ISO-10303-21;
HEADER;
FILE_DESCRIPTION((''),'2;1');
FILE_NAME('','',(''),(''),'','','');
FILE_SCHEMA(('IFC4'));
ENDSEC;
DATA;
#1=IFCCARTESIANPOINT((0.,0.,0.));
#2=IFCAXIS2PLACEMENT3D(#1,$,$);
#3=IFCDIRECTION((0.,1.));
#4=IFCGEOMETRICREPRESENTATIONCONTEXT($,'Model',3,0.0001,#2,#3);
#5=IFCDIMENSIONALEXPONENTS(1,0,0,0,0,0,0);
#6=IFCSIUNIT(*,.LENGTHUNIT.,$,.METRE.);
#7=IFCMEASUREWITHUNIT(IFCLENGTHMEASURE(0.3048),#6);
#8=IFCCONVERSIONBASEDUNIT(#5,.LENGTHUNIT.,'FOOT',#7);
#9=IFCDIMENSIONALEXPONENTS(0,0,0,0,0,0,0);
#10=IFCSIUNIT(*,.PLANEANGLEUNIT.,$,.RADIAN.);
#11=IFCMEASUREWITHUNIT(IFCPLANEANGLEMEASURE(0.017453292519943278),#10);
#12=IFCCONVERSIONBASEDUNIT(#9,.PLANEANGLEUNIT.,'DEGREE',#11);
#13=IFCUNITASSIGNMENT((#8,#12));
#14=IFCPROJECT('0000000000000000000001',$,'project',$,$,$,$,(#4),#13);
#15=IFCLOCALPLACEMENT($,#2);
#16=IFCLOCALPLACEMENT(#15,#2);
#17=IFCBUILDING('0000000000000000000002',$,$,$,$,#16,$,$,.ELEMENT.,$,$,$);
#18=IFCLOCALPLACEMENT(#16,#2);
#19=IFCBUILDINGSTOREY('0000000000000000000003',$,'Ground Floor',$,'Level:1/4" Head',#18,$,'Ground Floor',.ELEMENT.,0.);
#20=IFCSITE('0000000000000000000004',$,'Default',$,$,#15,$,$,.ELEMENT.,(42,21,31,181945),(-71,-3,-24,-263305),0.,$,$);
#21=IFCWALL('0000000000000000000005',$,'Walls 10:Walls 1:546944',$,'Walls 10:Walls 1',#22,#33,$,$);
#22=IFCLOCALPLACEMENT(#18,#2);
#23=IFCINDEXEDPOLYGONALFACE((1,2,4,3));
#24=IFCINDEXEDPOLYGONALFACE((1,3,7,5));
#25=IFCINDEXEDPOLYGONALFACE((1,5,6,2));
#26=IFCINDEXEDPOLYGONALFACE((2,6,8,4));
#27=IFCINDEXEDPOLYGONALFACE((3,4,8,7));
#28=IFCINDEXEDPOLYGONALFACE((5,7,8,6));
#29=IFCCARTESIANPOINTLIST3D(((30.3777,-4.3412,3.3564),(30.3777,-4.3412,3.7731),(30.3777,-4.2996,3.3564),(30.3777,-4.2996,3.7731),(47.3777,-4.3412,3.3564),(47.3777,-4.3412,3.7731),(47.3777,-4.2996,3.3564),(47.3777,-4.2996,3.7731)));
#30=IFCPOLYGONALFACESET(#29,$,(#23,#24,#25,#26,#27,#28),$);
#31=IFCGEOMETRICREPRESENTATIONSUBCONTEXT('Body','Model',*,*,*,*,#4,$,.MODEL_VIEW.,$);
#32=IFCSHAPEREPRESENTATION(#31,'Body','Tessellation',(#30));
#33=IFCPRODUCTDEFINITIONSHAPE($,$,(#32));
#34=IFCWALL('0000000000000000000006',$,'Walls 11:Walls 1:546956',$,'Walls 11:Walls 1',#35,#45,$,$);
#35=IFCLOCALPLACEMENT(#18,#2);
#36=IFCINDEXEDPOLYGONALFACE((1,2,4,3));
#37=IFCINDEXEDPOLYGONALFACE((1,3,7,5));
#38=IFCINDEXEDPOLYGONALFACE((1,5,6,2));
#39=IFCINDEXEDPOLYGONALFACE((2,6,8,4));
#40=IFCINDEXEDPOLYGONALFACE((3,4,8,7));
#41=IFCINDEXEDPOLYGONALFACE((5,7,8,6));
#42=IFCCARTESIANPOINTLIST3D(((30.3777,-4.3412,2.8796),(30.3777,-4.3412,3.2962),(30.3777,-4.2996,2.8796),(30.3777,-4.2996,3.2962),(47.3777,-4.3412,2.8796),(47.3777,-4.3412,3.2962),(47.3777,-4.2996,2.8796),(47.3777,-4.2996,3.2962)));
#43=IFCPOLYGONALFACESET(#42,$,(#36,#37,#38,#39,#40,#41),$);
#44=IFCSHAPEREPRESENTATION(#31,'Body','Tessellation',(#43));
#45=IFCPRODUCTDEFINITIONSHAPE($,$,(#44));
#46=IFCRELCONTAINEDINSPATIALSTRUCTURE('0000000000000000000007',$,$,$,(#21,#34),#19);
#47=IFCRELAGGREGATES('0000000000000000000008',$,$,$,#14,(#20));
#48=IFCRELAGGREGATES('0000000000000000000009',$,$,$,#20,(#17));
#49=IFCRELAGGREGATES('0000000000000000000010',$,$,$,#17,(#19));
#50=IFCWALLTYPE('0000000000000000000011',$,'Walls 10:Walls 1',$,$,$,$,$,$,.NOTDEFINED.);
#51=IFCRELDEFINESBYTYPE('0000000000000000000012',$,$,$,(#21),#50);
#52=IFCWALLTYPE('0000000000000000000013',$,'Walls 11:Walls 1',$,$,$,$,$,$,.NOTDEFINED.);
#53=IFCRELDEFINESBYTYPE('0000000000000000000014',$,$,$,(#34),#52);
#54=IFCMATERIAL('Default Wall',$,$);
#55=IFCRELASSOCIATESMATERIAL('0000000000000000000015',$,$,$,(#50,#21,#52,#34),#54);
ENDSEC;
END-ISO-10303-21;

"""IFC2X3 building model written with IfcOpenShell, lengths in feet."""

from ifc_helpers import new_model, entity, si_unit, converted_unit, direction, frame, frame_2d, origin, place, context, subcontext, project, spatial, rectangle, extrude, material, type_object, element, save


model = new_model("IFC2X3")

# Units and contexts
model_context = context("Model", 3, precision=0.0001, world=origin(), true_north=direction((0.0, 1.0)))
body_context = subcontext(model_context, "Body", "Model", "MODEL_VIEW")
ifc_project = project(units=[converted_unit("LENGTHUNIT", "FOOT", entity("IfcLengthMeasure", 0.3048), si_unit("LENGTHUNIT", "METRE"), dimensions=[1, 0, 0, 0, 0, 0, 0]), converted_unit("PLANEANGLEUNIT", "DEGREE", entity("IfcPlaneAngleMeasure", 0.017453292519943278), si_unit("PLANEANGLEUNIT", "RADIAN"), dimensions=[0, 0, 0, 0, 0, 0, 0])], contexts=[model_context])

# Site, building, storey
site_placement = place(None, origin())
site = spatial("IfcSite", under=ifc_project, at=site_placement, Name="Default", CompositionType="ELEMENT", RefLatitude=(42, 21, 31, 181945), RefLongitude=(-71, -3, -24, -263305), RefElevation=0.0)
building_placement = place(site_placement, origin())
building = spatial("IfcBuilding", under=site, at=building_placement, CompositionType="ELEMENT")
storey_placement = place(building_placement, origin())
storey = spatial("IfcBuildingStorey", under=building, at=storey_placement, Name="Ground Floor", ObjectType="Level:1/4\" Head", LongName="Ground Floor", CompositionType="ELEMENT", Elevation=0.0)

# Walls
ifc_material_1 = material(Name="Default Wall")
wall_type_1 = type_object("IfcWallType", Name="Walls 10:Walls 1", PredefinedType="NOTDEFINED", material=ifc_material_1)
wall_1_placement = place(storey_placement, frame((30.3777, -4.3412, 3.3564)))
element("IfcWall", 1, at=wall_1_placement, inside=storey, type_object=wall_type_1, material=ifc_material_1, Name="Walls 10:Walls 1:546944", ObjectType="Walls 10:Walls 1", context=body_context, shape_type="SweptSolid", body=[
    extrude(rectangle(XDim=0.0417, YDim=17.0, at=frame_2d((0.0, 0.0), x_axis=(1.0, 0.0))), frame((8.5, 0.0208, 0.0), z_axis=(0.0, 0.0, 1.0), x_axis=(0.0, -1.0, 0.0)), (0.0, 0.0, 1.0), 0.4167),
])
wall_type_2 = type_object("IfcWallType", Name="Walls 11:Walls 1", PredefinedType="NOTDEFINED", material=ifc_material_1)
wall_2_placement = place(storey_placement, frame((30.3777, -4.3412, 2.8796)))
element("IfcWall", 2, at=wall_2_placement, inside=storey, type_object=wall_type_2, material=ifc_material_1, Name="Walls 11:Walls 1:546956", ObjectType="Walls 11:Walls 1", context=body_context, shape_type="SweptSolid", body=[
    extrude(rectangle(XDim=0.0417, YDim=17.0, at=frame_2d((0.0, 0.0), x_axis=(1.0, 0.0))), frame((8.5, 0.0208, 0.0), z_axis=(0.0, 0.0, 1.0), x_axis=(0.0, -1.0, 0.0)), (0.0, 0.0, 1.0), 0.4167),
])

save(model, "model.ifc")
